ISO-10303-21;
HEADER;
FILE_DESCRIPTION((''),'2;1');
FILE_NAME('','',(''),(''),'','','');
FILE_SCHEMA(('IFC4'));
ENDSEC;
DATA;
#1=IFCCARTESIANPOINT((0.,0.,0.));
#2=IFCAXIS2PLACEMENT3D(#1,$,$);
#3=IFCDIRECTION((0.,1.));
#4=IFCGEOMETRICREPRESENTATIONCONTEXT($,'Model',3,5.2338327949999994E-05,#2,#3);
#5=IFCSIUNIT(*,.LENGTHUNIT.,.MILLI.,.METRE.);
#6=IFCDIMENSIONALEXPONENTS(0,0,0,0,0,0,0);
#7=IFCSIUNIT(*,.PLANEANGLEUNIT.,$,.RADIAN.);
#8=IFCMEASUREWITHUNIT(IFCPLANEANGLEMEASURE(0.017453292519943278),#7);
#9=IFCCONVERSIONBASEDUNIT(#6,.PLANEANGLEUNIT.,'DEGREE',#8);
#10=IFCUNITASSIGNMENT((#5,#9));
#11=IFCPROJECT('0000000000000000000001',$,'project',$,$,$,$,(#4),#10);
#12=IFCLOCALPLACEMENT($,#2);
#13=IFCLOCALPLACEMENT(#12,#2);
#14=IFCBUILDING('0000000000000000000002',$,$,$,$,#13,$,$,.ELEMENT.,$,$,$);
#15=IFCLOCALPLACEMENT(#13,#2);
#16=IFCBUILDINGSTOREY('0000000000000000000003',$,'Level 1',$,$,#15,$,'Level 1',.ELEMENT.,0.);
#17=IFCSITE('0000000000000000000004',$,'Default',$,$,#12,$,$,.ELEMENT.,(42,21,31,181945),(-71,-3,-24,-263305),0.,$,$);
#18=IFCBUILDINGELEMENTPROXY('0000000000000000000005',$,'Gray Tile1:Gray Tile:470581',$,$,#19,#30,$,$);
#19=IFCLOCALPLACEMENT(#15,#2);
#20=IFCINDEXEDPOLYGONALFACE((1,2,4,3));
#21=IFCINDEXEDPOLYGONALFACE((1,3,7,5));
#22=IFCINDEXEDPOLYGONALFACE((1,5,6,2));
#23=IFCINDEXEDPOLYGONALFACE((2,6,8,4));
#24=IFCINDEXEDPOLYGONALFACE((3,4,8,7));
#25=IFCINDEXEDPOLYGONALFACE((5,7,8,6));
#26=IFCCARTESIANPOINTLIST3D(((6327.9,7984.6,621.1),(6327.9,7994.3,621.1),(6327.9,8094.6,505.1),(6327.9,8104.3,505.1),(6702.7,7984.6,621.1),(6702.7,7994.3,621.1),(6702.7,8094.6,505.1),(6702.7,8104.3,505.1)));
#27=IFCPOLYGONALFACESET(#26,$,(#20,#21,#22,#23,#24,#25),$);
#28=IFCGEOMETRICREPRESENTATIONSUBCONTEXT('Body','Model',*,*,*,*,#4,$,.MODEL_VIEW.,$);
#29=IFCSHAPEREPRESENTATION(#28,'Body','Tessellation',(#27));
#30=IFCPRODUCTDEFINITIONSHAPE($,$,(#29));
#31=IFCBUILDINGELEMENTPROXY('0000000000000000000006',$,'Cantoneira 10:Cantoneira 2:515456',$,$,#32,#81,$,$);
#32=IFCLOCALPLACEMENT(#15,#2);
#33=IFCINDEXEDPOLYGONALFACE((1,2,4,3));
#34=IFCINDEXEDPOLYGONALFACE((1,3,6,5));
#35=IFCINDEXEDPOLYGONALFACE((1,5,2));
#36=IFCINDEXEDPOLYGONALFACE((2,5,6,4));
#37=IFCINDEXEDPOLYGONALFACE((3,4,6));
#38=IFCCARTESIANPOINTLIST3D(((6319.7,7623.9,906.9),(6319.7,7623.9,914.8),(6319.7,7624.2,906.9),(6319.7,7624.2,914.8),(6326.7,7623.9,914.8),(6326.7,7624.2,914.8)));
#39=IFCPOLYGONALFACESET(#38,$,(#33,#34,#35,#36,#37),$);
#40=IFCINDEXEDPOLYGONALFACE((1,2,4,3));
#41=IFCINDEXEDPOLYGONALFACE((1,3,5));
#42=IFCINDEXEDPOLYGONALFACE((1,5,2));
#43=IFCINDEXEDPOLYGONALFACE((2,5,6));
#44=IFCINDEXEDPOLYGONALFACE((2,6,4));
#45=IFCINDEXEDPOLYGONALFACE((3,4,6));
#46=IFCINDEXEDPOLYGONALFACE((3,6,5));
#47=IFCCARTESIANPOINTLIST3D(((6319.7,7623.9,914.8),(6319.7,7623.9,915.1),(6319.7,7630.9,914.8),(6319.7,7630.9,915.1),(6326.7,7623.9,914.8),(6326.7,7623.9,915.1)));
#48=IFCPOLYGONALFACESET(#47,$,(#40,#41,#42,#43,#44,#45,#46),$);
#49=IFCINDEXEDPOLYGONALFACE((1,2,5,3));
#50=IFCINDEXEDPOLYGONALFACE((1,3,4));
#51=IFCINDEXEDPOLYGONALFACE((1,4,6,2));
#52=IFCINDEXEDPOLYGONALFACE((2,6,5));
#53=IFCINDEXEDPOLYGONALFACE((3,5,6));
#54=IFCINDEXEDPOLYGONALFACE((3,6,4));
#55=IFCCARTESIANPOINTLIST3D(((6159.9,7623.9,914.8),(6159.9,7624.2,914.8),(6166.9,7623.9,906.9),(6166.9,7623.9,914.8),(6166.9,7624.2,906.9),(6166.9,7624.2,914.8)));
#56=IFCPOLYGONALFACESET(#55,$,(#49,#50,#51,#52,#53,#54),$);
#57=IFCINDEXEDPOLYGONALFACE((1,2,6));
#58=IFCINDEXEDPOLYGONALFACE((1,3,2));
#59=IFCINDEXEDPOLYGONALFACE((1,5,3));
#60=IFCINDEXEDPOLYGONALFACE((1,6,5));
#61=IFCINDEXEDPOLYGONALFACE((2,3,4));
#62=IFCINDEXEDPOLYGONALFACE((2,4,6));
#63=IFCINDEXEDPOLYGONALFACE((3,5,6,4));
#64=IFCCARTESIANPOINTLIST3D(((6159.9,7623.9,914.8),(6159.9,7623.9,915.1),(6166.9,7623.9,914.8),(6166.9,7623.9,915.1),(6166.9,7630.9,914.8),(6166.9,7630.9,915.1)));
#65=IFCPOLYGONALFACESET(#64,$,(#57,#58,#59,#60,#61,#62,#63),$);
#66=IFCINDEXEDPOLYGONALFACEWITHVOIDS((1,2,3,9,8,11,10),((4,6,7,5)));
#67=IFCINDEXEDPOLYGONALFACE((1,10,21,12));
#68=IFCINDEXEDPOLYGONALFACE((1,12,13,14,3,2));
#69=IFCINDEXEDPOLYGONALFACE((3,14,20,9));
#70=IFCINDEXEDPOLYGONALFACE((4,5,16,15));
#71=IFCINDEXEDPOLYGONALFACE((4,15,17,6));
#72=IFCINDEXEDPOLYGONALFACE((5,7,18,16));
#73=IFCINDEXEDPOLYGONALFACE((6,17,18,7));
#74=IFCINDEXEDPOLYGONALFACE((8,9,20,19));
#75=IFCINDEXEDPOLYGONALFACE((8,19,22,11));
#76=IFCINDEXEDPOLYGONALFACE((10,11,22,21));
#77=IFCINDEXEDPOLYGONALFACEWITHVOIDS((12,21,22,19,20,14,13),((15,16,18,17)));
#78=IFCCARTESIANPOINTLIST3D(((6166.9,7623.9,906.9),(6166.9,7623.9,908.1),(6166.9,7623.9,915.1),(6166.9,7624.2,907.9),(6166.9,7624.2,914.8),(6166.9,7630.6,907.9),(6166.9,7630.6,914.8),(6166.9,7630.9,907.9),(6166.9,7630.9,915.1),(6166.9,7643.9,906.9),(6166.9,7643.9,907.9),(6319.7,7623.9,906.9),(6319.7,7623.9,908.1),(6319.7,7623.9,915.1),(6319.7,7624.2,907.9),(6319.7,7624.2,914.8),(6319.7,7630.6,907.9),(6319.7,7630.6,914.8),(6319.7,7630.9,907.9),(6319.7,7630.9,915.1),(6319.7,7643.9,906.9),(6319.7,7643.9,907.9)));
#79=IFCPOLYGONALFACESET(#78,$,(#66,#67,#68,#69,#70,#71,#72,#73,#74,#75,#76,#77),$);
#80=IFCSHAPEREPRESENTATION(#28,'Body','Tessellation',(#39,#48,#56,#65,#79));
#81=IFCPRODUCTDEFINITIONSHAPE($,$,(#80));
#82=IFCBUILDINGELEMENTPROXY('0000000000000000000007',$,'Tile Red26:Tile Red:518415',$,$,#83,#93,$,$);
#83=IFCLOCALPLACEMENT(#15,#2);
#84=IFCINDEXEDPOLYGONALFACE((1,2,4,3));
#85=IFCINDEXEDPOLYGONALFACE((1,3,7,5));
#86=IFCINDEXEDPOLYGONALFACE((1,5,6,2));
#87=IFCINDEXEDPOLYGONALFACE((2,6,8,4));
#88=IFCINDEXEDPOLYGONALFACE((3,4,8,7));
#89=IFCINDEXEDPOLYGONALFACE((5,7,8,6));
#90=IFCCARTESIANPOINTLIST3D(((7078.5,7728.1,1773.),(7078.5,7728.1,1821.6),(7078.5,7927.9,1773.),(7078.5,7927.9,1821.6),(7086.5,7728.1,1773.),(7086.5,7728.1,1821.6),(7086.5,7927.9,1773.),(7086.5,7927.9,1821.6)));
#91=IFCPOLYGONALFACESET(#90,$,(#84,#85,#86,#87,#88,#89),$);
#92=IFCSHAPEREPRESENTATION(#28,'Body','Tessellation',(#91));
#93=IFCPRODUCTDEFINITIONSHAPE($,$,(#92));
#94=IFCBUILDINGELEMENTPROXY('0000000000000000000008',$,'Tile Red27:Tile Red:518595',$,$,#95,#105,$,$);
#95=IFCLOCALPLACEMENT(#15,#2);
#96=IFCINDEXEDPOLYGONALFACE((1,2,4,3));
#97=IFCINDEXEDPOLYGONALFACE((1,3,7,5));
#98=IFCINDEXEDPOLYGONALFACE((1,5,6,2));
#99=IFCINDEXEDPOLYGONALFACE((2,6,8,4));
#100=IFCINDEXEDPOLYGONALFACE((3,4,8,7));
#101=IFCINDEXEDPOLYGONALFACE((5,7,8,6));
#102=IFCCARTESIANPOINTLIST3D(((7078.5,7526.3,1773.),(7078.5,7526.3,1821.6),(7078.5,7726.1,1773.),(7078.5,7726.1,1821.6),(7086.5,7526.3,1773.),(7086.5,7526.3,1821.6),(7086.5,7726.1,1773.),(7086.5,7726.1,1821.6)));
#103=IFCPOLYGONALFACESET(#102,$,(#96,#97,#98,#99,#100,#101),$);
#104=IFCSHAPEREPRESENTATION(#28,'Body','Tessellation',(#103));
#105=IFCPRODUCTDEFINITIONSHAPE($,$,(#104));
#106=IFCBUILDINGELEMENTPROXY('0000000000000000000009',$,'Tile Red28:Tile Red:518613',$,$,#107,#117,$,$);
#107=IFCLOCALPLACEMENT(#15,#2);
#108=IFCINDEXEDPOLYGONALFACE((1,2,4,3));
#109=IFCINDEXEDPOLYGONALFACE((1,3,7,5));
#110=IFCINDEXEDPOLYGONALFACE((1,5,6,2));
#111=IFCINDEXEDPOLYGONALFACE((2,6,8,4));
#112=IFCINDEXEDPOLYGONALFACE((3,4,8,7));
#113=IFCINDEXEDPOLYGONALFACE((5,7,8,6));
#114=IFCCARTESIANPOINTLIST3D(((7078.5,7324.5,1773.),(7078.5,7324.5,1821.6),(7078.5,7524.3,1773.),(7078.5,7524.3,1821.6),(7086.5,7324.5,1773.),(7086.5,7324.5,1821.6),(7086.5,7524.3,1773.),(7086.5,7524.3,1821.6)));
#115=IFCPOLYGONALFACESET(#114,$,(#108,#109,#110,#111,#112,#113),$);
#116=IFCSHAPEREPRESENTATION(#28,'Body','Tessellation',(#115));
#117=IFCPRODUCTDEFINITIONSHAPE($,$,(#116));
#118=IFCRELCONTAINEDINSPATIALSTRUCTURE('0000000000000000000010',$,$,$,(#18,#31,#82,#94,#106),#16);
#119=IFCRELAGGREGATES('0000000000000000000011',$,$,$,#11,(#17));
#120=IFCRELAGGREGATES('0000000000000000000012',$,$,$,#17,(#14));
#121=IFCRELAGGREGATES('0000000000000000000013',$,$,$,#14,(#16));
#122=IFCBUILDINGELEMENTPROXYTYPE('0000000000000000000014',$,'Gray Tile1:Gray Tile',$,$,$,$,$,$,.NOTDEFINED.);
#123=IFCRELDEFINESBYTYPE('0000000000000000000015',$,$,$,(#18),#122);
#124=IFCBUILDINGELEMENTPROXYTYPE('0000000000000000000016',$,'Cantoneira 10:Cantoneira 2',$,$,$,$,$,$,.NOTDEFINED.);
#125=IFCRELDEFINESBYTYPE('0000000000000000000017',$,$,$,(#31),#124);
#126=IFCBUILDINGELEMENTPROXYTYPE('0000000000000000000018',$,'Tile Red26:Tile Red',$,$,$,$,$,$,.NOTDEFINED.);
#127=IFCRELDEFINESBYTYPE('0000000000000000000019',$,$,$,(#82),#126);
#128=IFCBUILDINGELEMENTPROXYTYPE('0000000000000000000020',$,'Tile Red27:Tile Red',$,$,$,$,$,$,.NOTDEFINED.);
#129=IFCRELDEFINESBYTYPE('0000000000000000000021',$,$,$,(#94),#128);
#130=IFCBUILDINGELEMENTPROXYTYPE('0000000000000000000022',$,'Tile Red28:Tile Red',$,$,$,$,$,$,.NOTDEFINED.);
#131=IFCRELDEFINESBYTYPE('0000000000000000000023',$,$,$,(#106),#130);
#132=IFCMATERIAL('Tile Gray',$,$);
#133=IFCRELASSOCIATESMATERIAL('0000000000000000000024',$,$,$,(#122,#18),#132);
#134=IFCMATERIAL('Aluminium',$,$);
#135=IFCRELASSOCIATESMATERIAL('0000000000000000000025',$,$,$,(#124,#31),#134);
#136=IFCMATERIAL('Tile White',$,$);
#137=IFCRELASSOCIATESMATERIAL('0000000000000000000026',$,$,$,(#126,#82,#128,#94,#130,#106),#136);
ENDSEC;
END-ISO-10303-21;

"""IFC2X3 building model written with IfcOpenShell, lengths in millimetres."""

from ifc_helpers import new_model, entity, si_unit, converted_unit, direction, frame, origin, origin_2d_with_axis, place, context, subcontext, project, spatial, polyline, rectangle, outline, extrude, source, transform, mapped, material, type_object, type_shapes, element, save


model = new_model("IFC2X3")

# Units and contexts
model_context = context("Model", 3, precision=5.2338327949999994e-05, world=origin(), true_north=direction((0.0, 1.0)))
body_context = subcontext(model_context, "Body", "Model", "MODEL_VIEW")
ifc_project = project(units=[si_unit("LENGTHUNIT", "METRE", prefix="MILLI"), converted_unit("PLANEANGLEUNIT", "DEGREE", entity("IfcPlaneAngleMeasure", 0.017453292519943278), si_unit("PLANEANGLEUNIT", "RADIAN"), dimensions=[0, 0, 0, 0, 0, 0, 0])], contexts=[model_context])

# Site, building, storey
site_placement = place(None, origin())
site = spatial("IfcSite", under=ifc_project, at=site_placement, Name="Default", CompositionType="ELEMENT", RefLatitude=(42, 21, 31, 181945), RefLongitude=(-71, -3, -24, -263305), RefElevation=0.0)
building_placement = place(site_placement, origin())
building = spatial("IfcBuilding", under=site, at=building_placement, CompositionType="ELEMENT")
storey_placement = place(building_placement, origin())
storey = spatial("IfcBuildingStorey", under=building, at=storey_placement, Name="Level 1", LongName="Level 1", CompositionType="ELEMENT", Elevation=0.0)

# Building element proxies
ifc_material_1 = material(Name="Tile Gray")
building_element_proxy_type_1 = type_object("IfcBuildingElementProxyType", Name="Gray Tile1:Gray Tile", PredefinedType="NOTDEFINED", material=ifc_material_1)
shared_shape_1 = source(origin(), body_context, "Body", "SweptSolid", [
    extrude(outline(polyline([(-83.3, -3.5), (76.6, -3.5), (83.3, 3.5), (-76.6, 3.5), (-83.3, -3.5)])), frame((6327.9, 8039.2, 555.7), z_axis=(1.0, 0.0, 0.0), x_axis=(0.0, -0.688092, 0.725624)), (0.0, 0.0, 1.0), 374.8),
])
type_shapes(building_element_proxy_type_1, [shared_shape_1])
proxy_1_placement = place(storey_placement, frame((0.0, 5.2, 7.5)))
element("IfcBuildingElementProxy", 1, at=proxy_1_placement, inside=storey, type_object=building_element_proxy_type_1, material=ifc_material_1, Name="Gray Tile1:Gray Tile:470581", context=body_context, shape_type="MappedRepresentation", body=[
    mapped(shared_shape_1, transform((0.0, 0.0, 0.0), scale=1.0)),
])
ifc_material_2 = material(Name="Aluminium")
building_element_proxy_type_2 = type_object("IfcBuildingElementProxyType", Name="Cantoneira 10:Cantoneira 2", PredefinedType="NOTDEFINED", material=ifc_material_2)
shared_shape_2 = source(origin(), body_context, "Body", "SweptSolid", [
    extrude(outline(polyline([(-5.1, -1.7), (5.5, -1.7), (-0.4, 3.5), (-5.1, -1.7)])), frame((6322.0, 7623.9, 912.2), z_axis=(0.0, 1.0, 0.0), x_axis=(-0.664803, 0.0, -0.747019)), (0.0, 0.0, 1.0), 0.3),
    extrude(outline(polyline([(-4.7, -2.3), (2.3, -2.3), (2.3, 4.7), (-4.7, -2.3)])), frame((6322.0, 7626.2, 914.8), z_axis=(0.0, 0.0, 1.0), x_axis=(0.0, -1.0, 0.0)), (0.0, 0.0, 1.0), 0.3),
    extrude(outline(polyline([(-4.7, -2.6), (2.3, -2.6), (2.3, 5.2), (-4.7, -2.6)])), frame((6164.6, 7623.9, 912.2), z_axis=(0.0, 1.0, 0.0), x_axis=(1.0, 0.0, 0.0)), (0.0, 0.0, 1.0), 0.3),
    extrude(outline(polyline([(-4.9, -1.6), (4.9, -1.6), (0.0, 3.3), (-4.9, -1.6)])), frame((6164.6, 7626.2, 914.8), z_axis=(0.0, 0.0, 1.0), x_axis=(-0.707107, -0.707107, 0.0)), (0.0, 0.0, 1.0), 0.3),
    extrude(outline(polyline([(1.6, -7.7), (2.8, -7.7), (2.8, 12.3), (1.8, 12.3), (1.8, -0.7), (-5.4, -0.7), (-5.4, -7.7), (1.6, -7.7)]), holes=[polyline([(-5.1, -1.0), (1.8, -1.0), (1.8, -7.4), (-5.1, -7.4), (-5.1, -1.0)])]), frame((6166.9, 7631.6, 909.7), z_axis=(1.0, 0.0, 0.0), x_axis=(0.0, 0.0, -1.0)), (0.0, 0.0, 1.0), 152.8),
])
type_shapes(building_element_proxy_type_2, [shared_shape_2])
proxy_2_placement = place(storey_placement, origin())
element("IfcBuildingElementProxy", 2, at=proxy_2_placement, inside=storey, type_object=building_element_proxy_type_2, material=ifc_material_2, Name="Cantoneira 10:Cantoneira 2:515456", context=body_context, shape_type="MappedRepresentation", body=[
    mapped(shared_shape_2, transform((0.0, 0.0, 0.0), scale=1.0)),
])
ifc_material_3 = material(Name="Tile White")
building_element_proxy_type_3 = type_object("IfcBuildingElementProxyType", Name="Tile Red26:Tile Red", PredefinedType="NOTDEFINED", material=ifc_material_3)
shared_shape_3 = source(origin(), body_context, "Body", "SweptSolid", [
    extrude(rectangle(XDim=8.0, YDim=199.8, at=origin_2d_with_axis()), frame((7082.5, 7828.0, 1773.0)), (0.0, 0.0, 1.0), 48.6),
])
type_shapes(building_element_proxy_type_3, [shared_shape_3])
proxy_3_placement = place(storey_placement, origin())
element("IfcBuildingElementProxy", 3, at=proxy_3_placement, inside=storey, type_object=building_element_proxy_type_3, material=ifc_material_3, Name="Tile Red26:Tile Red:518415", context=body_context, shape_type="MappedRepresentation", body=[
    mapped(shared_shape_3, transform((0.0, 0.0, 0.0), scale=1.0)),
])
building_element_proxy_type_4 = type_object("IfcBuildingElementProxyType", Name="Tile Red27:Tile Red", PredefinedType="NOTDEFINED", material=ifc_material_3)
shared_shape_4 = source(origin(), body_context, "Body", "SweptSolid", [
    extrude(rectangle(XDim=8.0, YDim=199.8, at=origin_2d_with_axis()), frame((7082.5, 7626.2, 1773.0)), (0.0, 0.0, 1.0), 48.6),
])
type_shapes(building_element_proxy_type_4, [shared_shape_4])
proxy_4_placement = place(storey_placement, origin())
element("IfcBuildingElementProxy", 4, at=proxy_4_placement, inside=storey, type_object=building_element_proxy_type_4, material=ifc_material_3, Name="Tile Red27:Tile Red:518595", context=body_context, shape_type="MappedRepresentation", body=[
    mapped(shared_shape_4, transform((0.0, 0.0, 0.0), scale=1.0)),
])
building_element_proxy_type_5 = type_object("IfcBuildingElementProxyType", Name="Tile Red28:Tile Red", PredefinedType="NOTDEFINED", material=ifc_material_3)
shared_shape_5 = source(origin(), body_context, "Body", "SweptSolid", [
    extrude(rectangle(XDim=8.0, YDim=199.8, at=origin_2d_with_axis()), frame((7082.5, 7424.4, 1773.0)), (0.0, 0.0, 1.0), 48.6),
])
type_shapes(building_element_proxy_type_5, [shared_shape_5])
proxy_5_placement = place(storey_placement, origin())
element("IfcBuildingElementProxy", 5, at=proxy_5_placement, inside=storey, type_object=building_element_proxy_type_5, material=ifc_material_3, Name="Tile Red28:Tile Red:518613", context=body_context, shape_type="MappedRepresentation", body=[
    mapped(shared_shape_5, transform((0.0, 0.0, 0.0), scale=1.0)),
])

save(model, "model.ifc")
